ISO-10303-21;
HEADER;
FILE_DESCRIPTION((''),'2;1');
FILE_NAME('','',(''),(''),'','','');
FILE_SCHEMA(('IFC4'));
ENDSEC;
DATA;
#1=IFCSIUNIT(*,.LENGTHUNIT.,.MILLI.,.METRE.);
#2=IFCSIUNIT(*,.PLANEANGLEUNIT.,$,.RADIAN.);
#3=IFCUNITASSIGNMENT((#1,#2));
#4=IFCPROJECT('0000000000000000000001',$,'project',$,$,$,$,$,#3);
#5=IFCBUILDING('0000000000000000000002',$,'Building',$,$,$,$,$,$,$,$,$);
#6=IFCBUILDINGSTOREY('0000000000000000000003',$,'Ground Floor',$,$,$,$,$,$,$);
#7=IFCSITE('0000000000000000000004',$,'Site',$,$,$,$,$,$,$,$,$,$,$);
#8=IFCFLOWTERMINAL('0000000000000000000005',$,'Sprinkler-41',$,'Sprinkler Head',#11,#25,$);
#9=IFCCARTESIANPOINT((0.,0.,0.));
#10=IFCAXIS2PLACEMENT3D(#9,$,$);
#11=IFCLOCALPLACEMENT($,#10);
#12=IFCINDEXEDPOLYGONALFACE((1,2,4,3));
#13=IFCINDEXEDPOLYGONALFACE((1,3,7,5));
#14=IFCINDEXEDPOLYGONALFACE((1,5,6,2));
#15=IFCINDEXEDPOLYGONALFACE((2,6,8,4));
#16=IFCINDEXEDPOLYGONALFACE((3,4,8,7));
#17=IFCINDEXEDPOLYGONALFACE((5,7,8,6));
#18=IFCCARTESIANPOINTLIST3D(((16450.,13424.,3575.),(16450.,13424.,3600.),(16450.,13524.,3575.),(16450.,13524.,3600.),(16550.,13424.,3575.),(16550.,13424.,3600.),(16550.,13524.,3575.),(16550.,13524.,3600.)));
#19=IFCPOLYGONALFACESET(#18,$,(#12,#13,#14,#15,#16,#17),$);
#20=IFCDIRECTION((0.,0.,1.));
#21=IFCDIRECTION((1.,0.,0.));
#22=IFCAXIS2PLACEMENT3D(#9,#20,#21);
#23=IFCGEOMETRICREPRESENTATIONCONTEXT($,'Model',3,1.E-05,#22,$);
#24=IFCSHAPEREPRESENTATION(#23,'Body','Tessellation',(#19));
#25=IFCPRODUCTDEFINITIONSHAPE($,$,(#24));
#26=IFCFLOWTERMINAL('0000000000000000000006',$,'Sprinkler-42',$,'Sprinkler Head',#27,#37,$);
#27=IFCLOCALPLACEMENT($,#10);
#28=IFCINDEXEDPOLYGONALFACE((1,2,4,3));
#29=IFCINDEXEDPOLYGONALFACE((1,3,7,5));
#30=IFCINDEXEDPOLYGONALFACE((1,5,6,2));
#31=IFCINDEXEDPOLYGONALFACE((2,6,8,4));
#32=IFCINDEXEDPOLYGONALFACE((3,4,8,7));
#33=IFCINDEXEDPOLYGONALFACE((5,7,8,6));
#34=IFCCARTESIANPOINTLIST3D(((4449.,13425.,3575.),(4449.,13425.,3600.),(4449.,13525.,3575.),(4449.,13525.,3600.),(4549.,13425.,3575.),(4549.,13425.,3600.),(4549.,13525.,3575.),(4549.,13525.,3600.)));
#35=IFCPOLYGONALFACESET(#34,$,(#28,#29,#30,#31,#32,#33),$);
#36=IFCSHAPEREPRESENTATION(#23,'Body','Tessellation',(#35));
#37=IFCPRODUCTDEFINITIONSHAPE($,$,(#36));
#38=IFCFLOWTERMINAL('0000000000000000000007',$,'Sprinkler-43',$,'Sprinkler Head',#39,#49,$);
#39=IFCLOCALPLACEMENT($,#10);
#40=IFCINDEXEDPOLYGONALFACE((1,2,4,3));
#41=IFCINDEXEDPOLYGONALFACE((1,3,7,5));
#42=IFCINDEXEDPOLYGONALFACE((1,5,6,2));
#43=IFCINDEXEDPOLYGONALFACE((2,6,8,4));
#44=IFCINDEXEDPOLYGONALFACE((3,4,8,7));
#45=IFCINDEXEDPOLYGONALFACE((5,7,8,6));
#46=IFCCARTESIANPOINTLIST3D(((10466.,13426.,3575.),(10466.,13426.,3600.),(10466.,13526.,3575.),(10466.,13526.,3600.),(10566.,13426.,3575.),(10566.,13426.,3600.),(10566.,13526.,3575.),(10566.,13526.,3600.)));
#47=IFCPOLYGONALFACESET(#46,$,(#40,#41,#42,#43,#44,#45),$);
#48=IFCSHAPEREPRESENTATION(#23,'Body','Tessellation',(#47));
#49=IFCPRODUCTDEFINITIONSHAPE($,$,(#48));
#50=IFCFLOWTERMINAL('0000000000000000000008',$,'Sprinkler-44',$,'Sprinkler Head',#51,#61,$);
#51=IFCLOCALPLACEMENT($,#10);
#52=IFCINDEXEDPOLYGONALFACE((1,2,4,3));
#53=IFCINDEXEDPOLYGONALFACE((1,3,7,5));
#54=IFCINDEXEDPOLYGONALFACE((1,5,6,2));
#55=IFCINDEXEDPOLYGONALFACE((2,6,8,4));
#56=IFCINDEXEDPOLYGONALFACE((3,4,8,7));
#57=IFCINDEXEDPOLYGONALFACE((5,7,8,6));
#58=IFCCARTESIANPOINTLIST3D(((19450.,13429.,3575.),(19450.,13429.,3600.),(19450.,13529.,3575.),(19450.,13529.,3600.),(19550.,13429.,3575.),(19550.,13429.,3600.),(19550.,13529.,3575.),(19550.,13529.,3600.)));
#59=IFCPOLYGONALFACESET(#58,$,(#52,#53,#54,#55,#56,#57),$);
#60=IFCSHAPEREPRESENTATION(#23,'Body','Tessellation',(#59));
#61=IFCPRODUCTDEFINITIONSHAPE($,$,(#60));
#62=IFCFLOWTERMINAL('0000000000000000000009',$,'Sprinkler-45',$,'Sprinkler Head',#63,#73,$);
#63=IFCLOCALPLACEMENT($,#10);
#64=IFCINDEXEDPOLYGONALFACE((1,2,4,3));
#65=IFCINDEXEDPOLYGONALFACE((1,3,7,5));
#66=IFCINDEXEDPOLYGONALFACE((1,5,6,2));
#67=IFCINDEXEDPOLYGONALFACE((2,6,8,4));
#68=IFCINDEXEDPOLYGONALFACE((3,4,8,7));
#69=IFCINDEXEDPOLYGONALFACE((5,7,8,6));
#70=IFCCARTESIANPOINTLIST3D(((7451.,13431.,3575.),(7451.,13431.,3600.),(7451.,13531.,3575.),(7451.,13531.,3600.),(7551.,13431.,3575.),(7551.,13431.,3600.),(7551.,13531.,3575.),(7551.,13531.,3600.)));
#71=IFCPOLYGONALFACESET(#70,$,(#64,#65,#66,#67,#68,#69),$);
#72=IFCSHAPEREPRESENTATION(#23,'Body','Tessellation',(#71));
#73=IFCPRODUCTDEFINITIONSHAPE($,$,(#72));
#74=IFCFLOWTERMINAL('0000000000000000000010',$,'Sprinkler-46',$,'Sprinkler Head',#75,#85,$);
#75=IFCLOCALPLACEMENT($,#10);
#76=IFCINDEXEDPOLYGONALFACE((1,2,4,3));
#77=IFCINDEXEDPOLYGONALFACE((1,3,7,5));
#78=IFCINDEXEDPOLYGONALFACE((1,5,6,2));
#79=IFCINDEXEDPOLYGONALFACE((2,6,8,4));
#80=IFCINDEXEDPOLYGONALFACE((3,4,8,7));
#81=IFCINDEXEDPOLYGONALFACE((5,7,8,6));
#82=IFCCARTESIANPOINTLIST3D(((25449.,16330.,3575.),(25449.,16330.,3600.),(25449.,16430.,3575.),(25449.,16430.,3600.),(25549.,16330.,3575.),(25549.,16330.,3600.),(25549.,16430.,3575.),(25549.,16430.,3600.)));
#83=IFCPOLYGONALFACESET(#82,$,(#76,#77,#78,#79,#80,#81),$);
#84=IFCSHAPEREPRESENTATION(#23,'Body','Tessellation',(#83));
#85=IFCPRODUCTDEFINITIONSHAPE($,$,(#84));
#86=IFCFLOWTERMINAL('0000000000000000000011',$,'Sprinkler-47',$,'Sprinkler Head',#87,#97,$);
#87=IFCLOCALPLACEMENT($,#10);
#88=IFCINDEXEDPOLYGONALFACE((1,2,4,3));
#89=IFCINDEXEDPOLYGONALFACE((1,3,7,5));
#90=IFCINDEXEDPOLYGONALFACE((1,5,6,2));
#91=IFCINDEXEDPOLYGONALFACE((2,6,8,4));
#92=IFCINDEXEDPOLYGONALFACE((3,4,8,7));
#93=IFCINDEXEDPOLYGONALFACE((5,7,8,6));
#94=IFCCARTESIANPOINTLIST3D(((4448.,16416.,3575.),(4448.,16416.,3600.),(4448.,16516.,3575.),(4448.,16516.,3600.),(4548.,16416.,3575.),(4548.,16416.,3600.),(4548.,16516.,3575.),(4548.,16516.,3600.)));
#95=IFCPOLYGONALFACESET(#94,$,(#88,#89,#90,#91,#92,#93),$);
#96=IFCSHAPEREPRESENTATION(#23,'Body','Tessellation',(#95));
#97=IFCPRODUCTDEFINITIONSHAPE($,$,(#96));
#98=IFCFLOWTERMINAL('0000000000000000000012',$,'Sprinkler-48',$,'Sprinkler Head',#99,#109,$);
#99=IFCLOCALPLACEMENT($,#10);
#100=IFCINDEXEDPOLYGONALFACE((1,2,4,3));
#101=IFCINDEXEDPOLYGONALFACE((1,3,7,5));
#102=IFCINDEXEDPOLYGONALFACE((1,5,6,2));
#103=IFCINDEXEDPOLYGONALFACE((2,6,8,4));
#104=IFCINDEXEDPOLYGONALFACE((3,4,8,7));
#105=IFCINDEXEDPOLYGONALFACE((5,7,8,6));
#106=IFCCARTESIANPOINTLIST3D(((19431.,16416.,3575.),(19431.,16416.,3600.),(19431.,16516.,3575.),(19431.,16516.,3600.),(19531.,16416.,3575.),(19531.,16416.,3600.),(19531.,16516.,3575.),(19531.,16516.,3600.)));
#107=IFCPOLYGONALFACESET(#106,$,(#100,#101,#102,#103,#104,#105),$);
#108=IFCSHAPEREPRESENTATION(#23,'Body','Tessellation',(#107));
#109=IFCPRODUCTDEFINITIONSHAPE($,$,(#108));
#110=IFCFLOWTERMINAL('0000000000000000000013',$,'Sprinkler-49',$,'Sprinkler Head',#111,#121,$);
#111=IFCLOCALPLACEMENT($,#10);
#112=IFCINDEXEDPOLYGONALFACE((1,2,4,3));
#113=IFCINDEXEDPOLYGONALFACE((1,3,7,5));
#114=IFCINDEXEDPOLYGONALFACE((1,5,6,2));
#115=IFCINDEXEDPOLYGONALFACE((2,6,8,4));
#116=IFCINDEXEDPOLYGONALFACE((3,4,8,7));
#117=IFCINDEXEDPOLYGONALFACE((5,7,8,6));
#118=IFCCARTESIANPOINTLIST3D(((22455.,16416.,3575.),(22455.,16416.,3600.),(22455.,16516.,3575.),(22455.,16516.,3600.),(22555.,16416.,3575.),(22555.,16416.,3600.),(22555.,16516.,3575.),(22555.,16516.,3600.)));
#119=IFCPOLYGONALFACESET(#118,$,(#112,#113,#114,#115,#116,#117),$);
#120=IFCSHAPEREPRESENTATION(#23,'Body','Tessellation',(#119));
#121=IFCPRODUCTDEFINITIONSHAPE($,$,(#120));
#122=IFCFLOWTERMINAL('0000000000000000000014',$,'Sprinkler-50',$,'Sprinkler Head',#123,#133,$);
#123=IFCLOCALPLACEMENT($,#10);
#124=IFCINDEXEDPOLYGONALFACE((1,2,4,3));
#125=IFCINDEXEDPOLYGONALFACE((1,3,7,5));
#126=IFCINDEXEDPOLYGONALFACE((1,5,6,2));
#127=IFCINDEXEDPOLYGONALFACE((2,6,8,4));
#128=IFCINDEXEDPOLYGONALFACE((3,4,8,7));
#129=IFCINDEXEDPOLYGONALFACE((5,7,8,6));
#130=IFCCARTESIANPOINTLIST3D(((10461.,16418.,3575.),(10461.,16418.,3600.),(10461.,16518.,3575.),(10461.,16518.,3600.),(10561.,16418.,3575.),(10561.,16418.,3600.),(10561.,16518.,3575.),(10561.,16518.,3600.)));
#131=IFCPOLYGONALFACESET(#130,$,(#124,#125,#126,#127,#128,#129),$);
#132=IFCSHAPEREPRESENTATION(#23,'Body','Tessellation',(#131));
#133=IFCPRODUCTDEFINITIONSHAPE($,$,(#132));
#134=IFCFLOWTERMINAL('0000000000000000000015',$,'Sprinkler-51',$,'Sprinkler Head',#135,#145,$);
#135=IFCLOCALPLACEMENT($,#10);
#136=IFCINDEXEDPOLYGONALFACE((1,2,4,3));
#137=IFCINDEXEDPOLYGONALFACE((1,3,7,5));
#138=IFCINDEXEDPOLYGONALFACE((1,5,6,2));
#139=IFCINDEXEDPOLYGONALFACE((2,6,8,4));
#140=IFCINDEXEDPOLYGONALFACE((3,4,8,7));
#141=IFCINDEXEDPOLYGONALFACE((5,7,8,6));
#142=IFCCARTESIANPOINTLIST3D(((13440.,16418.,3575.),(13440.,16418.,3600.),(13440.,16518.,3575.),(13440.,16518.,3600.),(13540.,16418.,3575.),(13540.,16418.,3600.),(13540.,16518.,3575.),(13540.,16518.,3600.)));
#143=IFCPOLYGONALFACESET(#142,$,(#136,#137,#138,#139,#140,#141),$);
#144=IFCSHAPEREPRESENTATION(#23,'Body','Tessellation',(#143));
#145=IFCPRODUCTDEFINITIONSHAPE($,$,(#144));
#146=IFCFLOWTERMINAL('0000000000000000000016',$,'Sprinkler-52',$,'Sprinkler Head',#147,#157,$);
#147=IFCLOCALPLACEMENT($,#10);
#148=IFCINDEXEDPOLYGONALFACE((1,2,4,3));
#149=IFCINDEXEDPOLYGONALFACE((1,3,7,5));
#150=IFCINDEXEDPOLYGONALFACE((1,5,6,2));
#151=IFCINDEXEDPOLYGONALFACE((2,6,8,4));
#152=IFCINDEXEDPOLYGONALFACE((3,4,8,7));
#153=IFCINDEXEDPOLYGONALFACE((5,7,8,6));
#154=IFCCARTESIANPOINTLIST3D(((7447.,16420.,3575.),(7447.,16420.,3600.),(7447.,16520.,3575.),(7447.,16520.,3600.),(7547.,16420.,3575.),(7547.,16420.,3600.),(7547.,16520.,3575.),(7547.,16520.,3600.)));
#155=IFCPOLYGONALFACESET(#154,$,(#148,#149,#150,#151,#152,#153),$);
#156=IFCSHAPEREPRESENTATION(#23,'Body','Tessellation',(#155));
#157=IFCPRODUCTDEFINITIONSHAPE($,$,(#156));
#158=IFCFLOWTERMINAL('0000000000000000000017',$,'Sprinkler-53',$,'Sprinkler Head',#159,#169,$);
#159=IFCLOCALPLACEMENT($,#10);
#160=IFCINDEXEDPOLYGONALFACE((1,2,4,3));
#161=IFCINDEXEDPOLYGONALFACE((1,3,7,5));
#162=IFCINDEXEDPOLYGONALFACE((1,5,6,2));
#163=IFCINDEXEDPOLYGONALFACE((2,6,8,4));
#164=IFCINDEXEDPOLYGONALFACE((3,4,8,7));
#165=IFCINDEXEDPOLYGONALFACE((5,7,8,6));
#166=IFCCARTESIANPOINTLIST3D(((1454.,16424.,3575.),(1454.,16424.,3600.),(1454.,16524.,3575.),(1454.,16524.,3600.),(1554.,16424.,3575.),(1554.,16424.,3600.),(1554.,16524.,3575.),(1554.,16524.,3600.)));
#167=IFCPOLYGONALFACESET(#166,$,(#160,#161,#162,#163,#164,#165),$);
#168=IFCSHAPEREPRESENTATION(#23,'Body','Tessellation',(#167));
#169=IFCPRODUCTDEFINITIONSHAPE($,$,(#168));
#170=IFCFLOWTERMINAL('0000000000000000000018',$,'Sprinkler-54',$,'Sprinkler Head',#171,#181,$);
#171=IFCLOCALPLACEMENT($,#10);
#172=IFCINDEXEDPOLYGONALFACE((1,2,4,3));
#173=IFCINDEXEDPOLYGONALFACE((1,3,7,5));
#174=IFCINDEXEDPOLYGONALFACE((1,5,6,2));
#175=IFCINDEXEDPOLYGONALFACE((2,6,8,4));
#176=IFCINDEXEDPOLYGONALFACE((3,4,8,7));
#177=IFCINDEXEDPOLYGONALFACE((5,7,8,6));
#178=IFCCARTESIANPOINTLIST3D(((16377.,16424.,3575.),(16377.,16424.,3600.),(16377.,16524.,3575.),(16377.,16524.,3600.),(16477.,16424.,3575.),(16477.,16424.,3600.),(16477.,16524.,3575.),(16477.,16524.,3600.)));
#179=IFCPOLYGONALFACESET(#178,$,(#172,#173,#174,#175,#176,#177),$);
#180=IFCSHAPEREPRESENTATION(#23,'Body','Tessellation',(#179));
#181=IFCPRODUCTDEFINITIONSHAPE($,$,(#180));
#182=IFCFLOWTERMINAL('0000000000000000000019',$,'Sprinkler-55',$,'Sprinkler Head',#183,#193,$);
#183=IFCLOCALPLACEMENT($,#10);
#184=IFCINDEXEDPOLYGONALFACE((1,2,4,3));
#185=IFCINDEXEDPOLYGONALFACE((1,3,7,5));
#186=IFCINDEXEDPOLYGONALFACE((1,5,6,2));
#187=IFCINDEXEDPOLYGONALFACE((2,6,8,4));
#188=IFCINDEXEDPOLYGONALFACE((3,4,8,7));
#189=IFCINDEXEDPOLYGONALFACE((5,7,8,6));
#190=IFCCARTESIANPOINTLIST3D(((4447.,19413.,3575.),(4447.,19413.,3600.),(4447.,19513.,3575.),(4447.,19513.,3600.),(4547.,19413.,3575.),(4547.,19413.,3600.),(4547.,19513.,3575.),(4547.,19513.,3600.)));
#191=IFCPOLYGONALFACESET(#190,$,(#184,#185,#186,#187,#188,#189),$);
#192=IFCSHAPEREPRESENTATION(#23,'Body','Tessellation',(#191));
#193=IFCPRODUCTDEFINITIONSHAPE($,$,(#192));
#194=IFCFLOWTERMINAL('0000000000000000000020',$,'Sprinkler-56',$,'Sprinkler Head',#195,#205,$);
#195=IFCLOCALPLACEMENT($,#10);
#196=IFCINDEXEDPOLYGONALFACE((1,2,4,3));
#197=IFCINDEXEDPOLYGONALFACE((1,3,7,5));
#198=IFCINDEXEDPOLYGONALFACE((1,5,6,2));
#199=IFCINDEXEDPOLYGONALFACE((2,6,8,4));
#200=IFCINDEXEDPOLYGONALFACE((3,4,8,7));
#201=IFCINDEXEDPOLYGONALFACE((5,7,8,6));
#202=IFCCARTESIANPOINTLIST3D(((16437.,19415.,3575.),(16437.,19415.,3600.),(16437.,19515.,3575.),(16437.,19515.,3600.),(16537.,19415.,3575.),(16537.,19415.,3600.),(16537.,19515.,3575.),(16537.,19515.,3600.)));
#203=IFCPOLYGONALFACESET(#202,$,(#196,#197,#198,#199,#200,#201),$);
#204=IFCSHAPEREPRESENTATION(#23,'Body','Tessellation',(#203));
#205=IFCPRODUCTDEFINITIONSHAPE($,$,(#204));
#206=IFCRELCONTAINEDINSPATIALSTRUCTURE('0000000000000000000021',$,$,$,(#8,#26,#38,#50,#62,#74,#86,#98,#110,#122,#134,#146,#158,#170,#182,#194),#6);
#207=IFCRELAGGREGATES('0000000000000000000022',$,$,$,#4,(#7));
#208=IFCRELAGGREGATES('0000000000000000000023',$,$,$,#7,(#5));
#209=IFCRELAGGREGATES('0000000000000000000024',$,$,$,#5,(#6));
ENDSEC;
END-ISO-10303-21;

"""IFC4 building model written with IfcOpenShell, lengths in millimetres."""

from ifc_helpers import new_model, si_unit, frame, origin_with_axes, place, context, project, spatial, rectangle, extrude, element, save


model = new_model("IFC4")

# Units and contexts
model_context = context("Model", 3, precision=1e-05, world=origin_with_axes())
ifc_project = project(units=[si_unit("LENGTHUNIT", "METRE", prefix="MILLI"), si_unit("PLANEANGLEUNIT", "RADIAN")])

# Site, building, storey
site = spatial("IfcSite", under=ifc_project, Name="Site")
building = spatial("IfcBuilding", under=site, Name="Building")
storey = spatial("IfcBuildingStorey", under=building, Name="Ground Floor")

# Flow terminals
flow_terminal_1_placement = place(None, origin_with_axes())
element("IfcFlowTerminal", 1, at=flow_terminal_1_placement, inside=storey, Name="Sprinkler-41", ObjectType="Sprinkler Head", context=model_context, shape_type="SweptSolid", body=[
    extrude(rectangle(XDim=100.0, YDim=100.0), frame((16500.0, 13474.0, 3575.0), z_axis=(0.0, 0.0, 1.0), x_axis=(1.0, 0.0, 0.0)), (0.0, 0.0, 1.0), 25.0),
])
flow_terminal_2_placement = place(None, origin_with_axes())
element("IfcFlowTerminal", 2, at=flow_terminal_2_placement, inside=storey, Name="Sprinkler-42", ObjectType="Sprinkler Head", context=model_context, shape_type="SweptSolid", body=[
    extrude(rectangle(XDim=100.0, YDim=100.0), frame((4499.0, 13475.0, 3575.0), z_axis=(0.0, 0.0, 1.0), x_axis=(1.0, 0.0, 0.0)), (0.0, 0.0, 1.0), 25.0),
])
flow_terminal_3_placement = place(None, origin_with_axes())
element("IfcFlowTerminal", 3, at=flow_terminal_3_placement, inside=storey, Name="Sprinkler-43", ObjectType="Sprinkler Head", context=model_context, shape_type="SweptSolid", body=[
    extrude(rectangle(XDim=100.0, YDim=100.0), frame((10516.0, 13476.0, 3575.0), z_axis=(0.0, 0.0, 1.0), x_axis=(1.0, 0.0, 0.0)), (0.0, 0.0, 1.0), 25.0),
])
flow_terminal_4_placement = place(None, origin_with_axes())
element("IfcFlowTerminal", 4, at=flow_terminal_4_placement, inside=storey, Name="Sprinkler-44", ObjectType="Sprinkler Head", context=model_context, shape_type="SweptSolid", body=[
    extrude(rectangle(XDim=100.0, YDim=100.0), frame((19500.0, 13479.0, 3575.0), z_axis=(0.0, 0.0, 1.0), x_axis=(1.0, 0.0, 0.0)), (0.0, 0.0, 1.0), 25.0),
])
flow_terminal_5_placement = place(None, origin_with_axes())
element("IfcFlowTerminal", 5, at=flow_terminal_5_placement, inside=storey, Name="Sprinkler-45", ObjectType="Sprinkler Head", context=model_context, shape_type="SweptSolid", body=[
    extrude(rectangle(XDim=100.0, YDim=100.0), frame((7501.0, 13481.0, 3575.0), z_axis=(0.0, 0.0, 1.0), x_axis=(1.0, 0.0, 0.0)), (0.0, 0.0, 1.0), 25.0),
])
flow_terminal_6_placement = place(None, origin_with_axes())
element("IfcFlowTerminal", 6, at=flow_terminal_6_placement, inside=storey, Name="Sprinkler-46", ObjectType="Sprinkler Head", context=model_context, shape_type="SweptSolid", body=[
    extrude(rectangle(XDim=100.0, YDim=100.0), frame((25499.0, 16380.0, 3575.0), z_axis=(0.0, 0.0, 1.0), x_axis=(1.0, 0.0, 0.0)), (0.0, 0.0, 1.0), 25.0),
])
flow_terminal_7_placement = place(None, origin_with_axes())
element("IfcFlowTerminal", 7, at=flow_terminal_7_placement, inside=storey, Name="Sprinkler-47", ObjectType="Sprinkler Head", context=model_context, shape_type="SweptSolid", body=[
    extrude(rectangle(XDim=100.0, YDim=100.0), frame((4498.0, 16466.0, 3575.0), z_axis=(0.0, 0.0, 1.0), x_axis=(1.0, 0.0, 0.0)), (0.0, 0.0, 1.0), 25.0),
])
flow_terminal_8_placement = place(None, origin_with_axes())
element("IfcFlowTerminal", 8, at=flow_terminal_8_placement, inside=storey, Name="Sprinkler-48", ObjectType="Sprinkler Head", context=model_context, shape_type="SweptSolid", body=[
    extrude(rectangle(XDim=100.0, YDim=100.0), frame((19481.0, 16466.0, 3575.0), z_axis=(0.0, 0.0, 1.0), x_axis=(1.0, 0.0, 0.0)), (0.0, 0.0, 1.0), 25.0),
])
flow_terminal_9_placement = place(None, origin_with_axes())
element("IfcFlowTerminal", 9, at=flow_terminal_9_placement, inside=storey, Name="Sprinkler-49", ObjectType="Sprinkler Head", context=model_context, shape_type="SweptSolid", body=[
    extrude(rectangle(XDim=100.0, YDim=100.0), frame((22505.0, 16466.0, 3575.0), z_axis=(0.0, 0.0, 1.0), x_axis=(1.0, 0.0, 0.0)), (0.0, 0.0, 1.0), 25.0),
])
flow_terminal_10_placement = place(None, origin_with_axes())
element("IfcFlowTerminal", 10, at=flow_terminal_10_placement, inside=storey, Name="Sprinkler-50", ObjectType="Sprinkler Head", context=model_context, shape_type="SweptSolid", body=[
    extrude(rectangle(XDim=100.0, YDim=100.0), frame((10511.0, 16468.0, 3575.0), z_axis=(0.0, 0.0, 1.0), x_axis=(1.0, 0.0, 0.0)), (0.0, 0.0, 1.0), 25.0),
])
flow_terminal_11_placement = place(None, origin_with_axes())
element("IfcFlowTerminal", 11, at=flow_terminal_11_placement, inside=storey, Name="Sprinkler-51", ObjectType="Sprinkler Head", context=model_context, shape_type="SweptSolid", body=[
    extrude(rectangle(XDim=100.0, YDim=100.0), frame((13490.0, 16468.0, 3575.0), z_axis=(0.0, 0.0, 1.0), x_axis=(1.0, 0.0, 0.0)), (0.0, 0.0, 1.0), 25.0),
])
flow_terminal_12_placement = place(None, origin_with_axes())
element("IfcFlowTerminal", 12, at=flow_terminal_12_placement, inside=storey, Name="Sprinkler-52", ObjectType="Sprinkler Head", context=model_context, shape_type="SweptSolid", body=[
    extrude(rectangle(XDim=100.0, YDim=100.0), frame((7497.0, 16470.0, 3575.0), z_axis=(0.0, 0.0, 1.0), x_axis=(1.0, 0.0, 0.0)), (0.0, 0.0, 1.0), 25.0),
])
flow_terminal_13_placement = place(None, origin_with_axes())
element("IfcFlowTerminal", 13, at=flow_terminal_13_placement, inside=storey, Name="Sprinkler-53", ObjectType="Sprinkler Head", context=model_context, shape_type="SweptSolid", body=[
    extrude(rectangle(XDim=100.0, YDim=100.0), frame((1504.0, 16474.0, 3575.0), z_axis=(0.0, 0.0, 1.0), x_axis=(1.0, 0.0, 0.0)), (0.0, 0.0, 1.0), 25.0),
])
flow_terminal_14_placement = place(None, origin_with_axes())
element("IfcFlowTerminal", 14, at=flow_terminal_14_placement, inside=storey, Name="Sprinkler-54", ObjectType="Sprinkler Head", context=model_context, shape_type="SweptSolid", body=[
    extrude(rectangle(XDim=100.0, YDim=100.0), frame((16427.0, 16474.0, 3575.0), z_axis=(0.0, 0.0, 1.0), x_axis=(1.0, 0.0, 0.0)), (0.0, 0.0, 1.0), 25.0),
])
flow_terminal_15_placement = place(None, origin_with_axes())
element("IfcFlowTerminal", 15, at=flow_terminal_15_placement, inside=storey, Name="Sprinkler-55", ObjectType="Sprinkler Head", context=model_context, shape_type="SweptSolid", body=[
    extrude(rectangle(XDim=100.0, YDim=100.0), frame((4497.0, 19463.0, 3575.0), z_axis=(0.0, 0.0, 1.0), x_axis=(1.0, 0.0, 0.0)), (0.0, 0.0, 1.0), 25.0),
])
flow_terminal_16_placement = place(None, origin_with_axes())
element("IfcFlowTerminal", 16, at=flow_terminal_16_placement, inside=storey, Name="Sprinkler-56", ObjectType="Sprinkler Head", context=model_context, shape_type="SweptSolid", body=[
    extrude(rectangle(XDim=100.0, YDim=100.0), frame((16487.0, 19465.0, 3575.0), z_axis=(0.0, 0.0, 1.0), x_axis=(1.0, 0.0, 0.0)), (0.0, 0.0, 1.0), 25.0),
])

save(model, "model.ifc")
